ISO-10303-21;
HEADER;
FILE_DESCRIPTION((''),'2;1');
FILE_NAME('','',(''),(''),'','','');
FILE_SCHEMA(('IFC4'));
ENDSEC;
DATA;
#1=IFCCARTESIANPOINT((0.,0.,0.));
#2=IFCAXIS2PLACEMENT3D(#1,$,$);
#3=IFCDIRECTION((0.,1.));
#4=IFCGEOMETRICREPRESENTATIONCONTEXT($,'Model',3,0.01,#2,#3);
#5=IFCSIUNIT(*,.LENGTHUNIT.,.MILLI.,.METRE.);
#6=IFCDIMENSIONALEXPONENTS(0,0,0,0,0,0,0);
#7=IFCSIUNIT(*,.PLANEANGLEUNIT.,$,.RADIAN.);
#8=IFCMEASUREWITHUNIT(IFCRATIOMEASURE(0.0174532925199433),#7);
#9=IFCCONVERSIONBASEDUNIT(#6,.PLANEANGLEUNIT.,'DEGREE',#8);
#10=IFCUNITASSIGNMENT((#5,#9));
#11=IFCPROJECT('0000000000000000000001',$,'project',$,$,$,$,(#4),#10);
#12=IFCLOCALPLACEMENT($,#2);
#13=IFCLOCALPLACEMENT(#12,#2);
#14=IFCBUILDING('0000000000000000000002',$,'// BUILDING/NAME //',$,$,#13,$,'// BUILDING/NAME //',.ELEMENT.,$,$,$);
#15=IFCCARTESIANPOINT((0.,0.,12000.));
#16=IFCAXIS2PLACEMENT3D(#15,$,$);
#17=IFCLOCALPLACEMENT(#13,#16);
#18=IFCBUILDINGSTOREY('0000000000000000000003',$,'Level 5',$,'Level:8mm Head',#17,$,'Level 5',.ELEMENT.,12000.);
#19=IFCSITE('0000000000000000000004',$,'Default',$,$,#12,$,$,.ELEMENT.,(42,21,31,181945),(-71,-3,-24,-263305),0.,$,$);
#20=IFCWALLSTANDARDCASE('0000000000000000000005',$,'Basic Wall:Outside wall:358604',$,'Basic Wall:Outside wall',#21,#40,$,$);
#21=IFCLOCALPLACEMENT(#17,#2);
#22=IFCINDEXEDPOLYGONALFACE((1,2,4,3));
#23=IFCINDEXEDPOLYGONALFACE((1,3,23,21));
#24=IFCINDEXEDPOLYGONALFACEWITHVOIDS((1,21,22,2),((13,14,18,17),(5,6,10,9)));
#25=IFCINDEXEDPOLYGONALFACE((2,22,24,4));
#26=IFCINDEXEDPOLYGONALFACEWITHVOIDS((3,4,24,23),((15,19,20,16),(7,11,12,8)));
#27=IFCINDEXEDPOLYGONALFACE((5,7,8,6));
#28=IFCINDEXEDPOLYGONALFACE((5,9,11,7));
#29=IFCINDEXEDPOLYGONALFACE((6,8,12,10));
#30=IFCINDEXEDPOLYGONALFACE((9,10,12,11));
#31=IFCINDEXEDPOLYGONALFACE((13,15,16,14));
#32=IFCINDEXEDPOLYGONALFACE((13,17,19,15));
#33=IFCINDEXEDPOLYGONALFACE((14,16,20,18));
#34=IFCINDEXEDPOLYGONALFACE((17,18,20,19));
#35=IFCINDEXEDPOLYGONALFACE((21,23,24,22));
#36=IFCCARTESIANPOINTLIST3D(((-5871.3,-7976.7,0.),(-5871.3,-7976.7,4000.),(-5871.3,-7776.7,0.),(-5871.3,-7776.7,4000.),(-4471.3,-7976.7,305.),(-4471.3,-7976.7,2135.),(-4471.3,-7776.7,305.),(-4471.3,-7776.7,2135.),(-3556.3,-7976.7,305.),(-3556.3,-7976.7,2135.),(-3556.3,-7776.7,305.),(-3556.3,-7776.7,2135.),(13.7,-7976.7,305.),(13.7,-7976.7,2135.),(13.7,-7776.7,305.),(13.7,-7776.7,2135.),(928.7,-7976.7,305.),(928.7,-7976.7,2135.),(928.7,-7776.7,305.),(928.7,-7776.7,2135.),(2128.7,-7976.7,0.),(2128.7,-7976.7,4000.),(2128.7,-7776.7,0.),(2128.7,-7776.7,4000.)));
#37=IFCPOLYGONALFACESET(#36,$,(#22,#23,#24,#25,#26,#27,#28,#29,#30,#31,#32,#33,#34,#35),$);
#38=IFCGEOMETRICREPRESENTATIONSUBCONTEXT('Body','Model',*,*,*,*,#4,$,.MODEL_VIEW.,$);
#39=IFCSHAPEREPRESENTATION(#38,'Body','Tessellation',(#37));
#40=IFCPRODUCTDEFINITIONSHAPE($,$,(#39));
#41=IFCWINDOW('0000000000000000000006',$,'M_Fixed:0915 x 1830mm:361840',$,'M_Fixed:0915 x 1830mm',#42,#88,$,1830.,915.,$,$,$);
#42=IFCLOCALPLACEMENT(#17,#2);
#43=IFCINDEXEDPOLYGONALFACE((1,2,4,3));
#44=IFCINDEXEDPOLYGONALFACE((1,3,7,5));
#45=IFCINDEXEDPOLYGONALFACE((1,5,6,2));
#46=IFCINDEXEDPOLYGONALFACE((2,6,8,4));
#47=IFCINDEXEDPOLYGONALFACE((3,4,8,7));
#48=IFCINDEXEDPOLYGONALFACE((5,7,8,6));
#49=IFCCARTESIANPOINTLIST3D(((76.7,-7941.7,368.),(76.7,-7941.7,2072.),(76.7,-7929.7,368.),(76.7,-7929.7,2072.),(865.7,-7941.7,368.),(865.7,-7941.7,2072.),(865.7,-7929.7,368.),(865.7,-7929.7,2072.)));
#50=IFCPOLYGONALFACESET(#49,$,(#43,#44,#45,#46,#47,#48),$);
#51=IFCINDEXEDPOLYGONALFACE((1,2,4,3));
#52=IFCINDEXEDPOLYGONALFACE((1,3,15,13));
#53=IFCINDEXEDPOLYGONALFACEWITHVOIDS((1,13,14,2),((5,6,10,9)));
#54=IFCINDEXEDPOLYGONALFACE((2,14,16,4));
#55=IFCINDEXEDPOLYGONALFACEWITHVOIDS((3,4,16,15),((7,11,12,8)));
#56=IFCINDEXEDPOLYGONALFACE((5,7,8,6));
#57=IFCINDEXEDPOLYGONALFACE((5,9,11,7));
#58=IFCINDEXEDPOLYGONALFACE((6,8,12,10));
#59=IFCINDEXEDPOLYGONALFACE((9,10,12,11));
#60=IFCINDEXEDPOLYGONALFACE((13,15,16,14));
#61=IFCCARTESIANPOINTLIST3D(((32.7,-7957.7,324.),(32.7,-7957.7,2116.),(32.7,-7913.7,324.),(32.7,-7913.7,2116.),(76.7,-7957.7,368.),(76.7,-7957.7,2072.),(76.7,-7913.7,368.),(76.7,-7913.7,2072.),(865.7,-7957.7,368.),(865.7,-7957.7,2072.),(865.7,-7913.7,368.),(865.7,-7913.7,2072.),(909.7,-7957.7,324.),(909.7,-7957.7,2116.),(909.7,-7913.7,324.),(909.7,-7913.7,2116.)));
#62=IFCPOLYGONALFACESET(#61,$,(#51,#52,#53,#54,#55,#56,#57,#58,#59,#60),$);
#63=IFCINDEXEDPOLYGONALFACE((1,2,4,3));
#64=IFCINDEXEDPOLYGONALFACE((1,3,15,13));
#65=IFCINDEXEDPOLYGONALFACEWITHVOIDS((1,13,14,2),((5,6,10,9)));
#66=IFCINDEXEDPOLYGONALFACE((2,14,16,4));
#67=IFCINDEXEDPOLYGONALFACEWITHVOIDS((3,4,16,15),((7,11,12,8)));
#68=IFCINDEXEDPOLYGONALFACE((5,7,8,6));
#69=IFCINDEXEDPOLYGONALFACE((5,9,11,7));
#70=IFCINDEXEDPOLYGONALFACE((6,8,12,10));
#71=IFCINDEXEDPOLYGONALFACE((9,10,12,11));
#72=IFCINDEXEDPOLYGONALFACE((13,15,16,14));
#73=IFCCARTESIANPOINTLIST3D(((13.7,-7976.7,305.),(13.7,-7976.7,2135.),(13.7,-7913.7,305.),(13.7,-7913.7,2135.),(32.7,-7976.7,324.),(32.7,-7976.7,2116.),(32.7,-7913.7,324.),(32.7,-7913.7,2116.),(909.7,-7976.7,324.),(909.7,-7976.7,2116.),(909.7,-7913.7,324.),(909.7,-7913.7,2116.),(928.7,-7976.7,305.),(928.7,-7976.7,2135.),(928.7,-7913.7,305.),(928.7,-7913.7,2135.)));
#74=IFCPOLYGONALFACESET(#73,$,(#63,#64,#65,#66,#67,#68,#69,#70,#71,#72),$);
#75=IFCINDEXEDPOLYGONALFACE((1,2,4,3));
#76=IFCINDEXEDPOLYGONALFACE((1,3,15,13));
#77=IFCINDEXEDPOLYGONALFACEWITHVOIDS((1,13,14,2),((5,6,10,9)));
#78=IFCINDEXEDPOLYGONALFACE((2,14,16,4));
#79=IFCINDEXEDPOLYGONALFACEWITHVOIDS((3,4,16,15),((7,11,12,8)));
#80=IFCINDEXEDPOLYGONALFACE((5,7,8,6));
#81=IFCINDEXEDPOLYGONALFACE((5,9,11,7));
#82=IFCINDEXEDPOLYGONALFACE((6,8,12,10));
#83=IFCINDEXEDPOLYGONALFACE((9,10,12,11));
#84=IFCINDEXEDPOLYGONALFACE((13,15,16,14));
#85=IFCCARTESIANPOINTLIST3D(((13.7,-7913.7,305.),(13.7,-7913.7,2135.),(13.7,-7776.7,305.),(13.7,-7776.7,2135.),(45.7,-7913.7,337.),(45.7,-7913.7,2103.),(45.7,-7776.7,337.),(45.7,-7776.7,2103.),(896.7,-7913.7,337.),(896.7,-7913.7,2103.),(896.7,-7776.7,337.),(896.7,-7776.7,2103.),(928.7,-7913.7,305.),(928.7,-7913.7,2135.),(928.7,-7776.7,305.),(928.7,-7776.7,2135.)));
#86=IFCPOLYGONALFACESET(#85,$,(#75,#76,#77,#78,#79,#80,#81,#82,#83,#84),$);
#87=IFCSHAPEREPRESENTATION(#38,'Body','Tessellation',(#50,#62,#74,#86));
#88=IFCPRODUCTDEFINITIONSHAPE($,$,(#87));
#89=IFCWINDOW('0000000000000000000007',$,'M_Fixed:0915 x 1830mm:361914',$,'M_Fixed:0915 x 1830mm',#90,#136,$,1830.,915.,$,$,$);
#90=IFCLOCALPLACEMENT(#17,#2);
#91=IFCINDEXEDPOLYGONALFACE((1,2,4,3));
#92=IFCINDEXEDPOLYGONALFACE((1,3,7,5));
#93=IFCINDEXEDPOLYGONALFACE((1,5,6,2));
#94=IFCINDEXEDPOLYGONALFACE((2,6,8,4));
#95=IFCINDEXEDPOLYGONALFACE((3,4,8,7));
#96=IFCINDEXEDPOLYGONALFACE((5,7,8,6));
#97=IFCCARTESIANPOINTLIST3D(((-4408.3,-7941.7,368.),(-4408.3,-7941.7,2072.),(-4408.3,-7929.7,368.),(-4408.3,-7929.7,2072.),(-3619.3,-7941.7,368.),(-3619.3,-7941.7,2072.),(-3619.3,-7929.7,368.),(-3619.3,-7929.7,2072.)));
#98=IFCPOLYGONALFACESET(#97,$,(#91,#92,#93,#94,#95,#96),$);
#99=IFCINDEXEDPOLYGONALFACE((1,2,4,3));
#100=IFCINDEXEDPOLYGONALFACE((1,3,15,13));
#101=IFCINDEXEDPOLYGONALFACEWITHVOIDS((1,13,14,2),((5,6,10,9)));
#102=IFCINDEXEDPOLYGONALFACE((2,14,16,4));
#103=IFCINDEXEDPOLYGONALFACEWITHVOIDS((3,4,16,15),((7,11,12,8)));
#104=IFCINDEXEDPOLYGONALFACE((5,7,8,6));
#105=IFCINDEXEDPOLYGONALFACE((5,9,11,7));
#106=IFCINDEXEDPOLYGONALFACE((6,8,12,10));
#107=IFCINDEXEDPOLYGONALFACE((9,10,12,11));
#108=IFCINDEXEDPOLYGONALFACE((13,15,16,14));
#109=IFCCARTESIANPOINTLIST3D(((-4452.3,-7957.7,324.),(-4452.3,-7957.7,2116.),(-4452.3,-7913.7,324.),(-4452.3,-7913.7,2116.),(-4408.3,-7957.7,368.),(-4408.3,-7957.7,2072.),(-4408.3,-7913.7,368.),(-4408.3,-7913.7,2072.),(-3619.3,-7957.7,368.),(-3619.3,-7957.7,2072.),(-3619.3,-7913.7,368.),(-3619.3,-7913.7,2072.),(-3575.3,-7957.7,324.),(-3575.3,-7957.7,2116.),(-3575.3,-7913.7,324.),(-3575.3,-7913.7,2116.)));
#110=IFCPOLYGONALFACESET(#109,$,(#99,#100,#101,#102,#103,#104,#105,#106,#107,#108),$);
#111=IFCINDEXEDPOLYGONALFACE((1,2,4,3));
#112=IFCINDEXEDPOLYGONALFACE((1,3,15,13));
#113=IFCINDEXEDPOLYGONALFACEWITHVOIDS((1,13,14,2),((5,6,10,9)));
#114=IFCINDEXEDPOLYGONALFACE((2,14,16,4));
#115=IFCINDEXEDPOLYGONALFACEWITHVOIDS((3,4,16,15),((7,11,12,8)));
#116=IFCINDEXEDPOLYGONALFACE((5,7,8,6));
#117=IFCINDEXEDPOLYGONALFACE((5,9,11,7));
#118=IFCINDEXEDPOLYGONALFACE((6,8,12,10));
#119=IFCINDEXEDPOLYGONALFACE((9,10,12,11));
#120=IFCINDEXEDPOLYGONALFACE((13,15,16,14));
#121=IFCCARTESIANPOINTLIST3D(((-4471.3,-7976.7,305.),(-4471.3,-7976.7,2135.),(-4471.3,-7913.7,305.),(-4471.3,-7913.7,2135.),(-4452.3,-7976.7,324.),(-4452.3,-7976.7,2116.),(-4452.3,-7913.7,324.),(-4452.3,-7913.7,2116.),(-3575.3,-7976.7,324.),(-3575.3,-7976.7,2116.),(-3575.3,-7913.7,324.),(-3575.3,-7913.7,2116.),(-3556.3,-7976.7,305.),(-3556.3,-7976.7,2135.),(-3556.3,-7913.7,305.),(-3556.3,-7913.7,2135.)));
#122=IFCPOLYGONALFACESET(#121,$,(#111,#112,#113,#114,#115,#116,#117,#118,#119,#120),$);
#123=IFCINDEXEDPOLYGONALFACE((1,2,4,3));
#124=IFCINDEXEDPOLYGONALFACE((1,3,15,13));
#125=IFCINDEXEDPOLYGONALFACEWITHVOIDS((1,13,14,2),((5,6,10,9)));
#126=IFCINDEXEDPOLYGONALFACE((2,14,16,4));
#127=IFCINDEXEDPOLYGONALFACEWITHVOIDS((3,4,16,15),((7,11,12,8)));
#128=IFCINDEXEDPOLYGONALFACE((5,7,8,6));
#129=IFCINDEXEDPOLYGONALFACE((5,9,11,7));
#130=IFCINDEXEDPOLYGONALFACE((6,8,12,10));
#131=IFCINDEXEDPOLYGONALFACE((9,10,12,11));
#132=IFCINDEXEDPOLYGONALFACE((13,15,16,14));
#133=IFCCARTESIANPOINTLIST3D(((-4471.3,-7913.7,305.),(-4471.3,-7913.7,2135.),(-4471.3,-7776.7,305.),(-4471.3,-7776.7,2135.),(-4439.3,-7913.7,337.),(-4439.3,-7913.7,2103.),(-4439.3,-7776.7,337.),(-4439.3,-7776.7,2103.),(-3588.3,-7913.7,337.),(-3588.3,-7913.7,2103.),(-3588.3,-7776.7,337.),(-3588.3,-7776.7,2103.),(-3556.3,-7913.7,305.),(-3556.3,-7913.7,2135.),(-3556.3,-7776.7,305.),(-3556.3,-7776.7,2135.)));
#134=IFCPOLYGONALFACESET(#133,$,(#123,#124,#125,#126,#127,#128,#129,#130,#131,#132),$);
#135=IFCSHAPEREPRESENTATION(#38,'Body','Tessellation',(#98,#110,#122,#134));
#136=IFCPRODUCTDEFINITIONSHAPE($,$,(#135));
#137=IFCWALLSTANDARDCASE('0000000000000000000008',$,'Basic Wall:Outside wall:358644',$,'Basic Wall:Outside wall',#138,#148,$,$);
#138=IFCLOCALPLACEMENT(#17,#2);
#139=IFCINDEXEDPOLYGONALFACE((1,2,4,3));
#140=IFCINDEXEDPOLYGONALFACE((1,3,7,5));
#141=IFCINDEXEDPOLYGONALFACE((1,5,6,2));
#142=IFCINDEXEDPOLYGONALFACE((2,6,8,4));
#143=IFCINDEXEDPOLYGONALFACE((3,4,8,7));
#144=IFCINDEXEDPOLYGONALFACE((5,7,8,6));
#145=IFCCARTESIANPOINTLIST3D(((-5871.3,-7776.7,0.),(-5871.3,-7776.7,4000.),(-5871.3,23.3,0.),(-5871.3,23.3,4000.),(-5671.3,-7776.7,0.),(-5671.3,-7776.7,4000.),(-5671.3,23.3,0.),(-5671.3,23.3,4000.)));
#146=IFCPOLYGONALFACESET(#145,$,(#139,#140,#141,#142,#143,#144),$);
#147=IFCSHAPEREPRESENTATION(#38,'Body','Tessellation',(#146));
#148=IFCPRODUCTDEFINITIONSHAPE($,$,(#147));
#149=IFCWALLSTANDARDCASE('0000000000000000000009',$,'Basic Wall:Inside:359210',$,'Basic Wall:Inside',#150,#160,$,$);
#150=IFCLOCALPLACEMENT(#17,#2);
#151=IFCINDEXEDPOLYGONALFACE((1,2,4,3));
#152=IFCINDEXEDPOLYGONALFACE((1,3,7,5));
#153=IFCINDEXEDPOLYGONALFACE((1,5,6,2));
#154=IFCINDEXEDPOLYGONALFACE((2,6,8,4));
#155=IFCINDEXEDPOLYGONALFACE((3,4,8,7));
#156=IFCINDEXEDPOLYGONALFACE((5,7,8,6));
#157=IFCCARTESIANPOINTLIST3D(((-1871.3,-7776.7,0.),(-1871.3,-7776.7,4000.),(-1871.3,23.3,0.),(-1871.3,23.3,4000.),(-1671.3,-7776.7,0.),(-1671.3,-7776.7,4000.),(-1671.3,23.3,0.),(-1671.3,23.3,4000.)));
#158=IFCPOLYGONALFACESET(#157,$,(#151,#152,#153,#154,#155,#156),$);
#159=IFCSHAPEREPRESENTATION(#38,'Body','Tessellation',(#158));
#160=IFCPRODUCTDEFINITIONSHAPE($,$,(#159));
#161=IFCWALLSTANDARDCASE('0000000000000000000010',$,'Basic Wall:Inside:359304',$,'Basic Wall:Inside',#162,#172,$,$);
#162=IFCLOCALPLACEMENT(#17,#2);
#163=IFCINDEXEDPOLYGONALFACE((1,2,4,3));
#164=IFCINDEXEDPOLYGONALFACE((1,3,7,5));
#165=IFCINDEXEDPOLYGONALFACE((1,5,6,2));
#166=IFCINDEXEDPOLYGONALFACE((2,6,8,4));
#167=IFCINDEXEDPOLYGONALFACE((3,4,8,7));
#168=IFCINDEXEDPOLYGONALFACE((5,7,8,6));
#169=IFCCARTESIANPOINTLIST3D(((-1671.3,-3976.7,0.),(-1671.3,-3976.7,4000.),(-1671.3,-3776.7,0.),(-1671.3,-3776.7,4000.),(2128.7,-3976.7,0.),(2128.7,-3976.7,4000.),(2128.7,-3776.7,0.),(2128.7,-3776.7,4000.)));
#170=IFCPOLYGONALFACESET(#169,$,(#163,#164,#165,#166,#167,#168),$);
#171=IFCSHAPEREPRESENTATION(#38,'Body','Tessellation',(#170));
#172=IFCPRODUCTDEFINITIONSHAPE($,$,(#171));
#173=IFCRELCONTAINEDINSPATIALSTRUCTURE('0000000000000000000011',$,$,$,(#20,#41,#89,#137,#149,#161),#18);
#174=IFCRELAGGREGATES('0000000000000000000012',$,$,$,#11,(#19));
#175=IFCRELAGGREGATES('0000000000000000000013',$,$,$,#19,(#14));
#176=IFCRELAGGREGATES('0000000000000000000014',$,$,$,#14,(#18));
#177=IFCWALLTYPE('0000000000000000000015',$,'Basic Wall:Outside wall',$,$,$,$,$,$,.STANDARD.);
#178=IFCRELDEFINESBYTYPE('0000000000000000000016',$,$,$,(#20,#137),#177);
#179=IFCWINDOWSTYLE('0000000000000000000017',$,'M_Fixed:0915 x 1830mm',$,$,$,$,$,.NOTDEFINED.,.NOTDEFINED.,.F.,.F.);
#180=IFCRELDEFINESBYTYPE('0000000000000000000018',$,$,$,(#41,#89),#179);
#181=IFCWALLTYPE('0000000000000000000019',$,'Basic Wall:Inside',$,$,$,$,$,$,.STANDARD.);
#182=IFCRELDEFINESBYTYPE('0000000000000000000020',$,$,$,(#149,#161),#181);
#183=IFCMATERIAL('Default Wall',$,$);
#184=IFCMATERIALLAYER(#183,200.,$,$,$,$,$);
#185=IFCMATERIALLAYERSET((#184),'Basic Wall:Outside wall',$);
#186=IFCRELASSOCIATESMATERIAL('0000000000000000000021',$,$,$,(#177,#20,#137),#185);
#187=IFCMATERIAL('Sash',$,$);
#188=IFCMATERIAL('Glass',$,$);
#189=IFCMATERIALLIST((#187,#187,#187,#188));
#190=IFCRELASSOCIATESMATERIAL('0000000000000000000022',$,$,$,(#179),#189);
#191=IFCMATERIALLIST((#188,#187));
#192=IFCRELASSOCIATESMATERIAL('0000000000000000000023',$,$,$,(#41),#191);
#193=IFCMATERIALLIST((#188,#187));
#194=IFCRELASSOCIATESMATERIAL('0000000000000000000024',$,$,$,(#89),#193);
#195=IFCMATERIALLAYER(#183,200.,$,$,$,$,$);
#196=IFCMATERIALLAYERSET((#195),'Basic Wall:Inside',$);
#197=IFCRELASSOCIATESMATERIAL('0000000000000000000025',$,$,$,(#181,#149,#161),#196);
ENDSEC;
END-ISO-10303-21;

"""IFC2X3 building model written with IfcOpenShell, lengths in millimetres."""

from ifc_helpers import new_model, entity, si_unit, converted_unit, direction, frame, frame_2d, origin, place, context, subcontext, project, spatial, polyline, rectangle, outline, extrude, clip, halfspace, source, transform, mapped, material, material_list, layer, layer_set, layer_usage, type_object, type_shapes, element, fill, save


model = new_model("IFC2X3")

# Units and contexts
model_context = context("Model", 3, precision=0.01, world=origin(), true_north=direction((0.0, 1.0)))
body_context = subcontext(model_context, "Body", "Model", "MODEL_VIEW")
ifc_project = project(units=[si_unit("LENGTHUNIT", "METRE", prefix="MILLI"), converted_unit("PLANEANGLEUNIT", "DEGREE", entity("IfcRatioMeasure", 0.0174532925199433), si_unit("PLANEANGLEUNIT", "RADIAN"), dimensions=[0, 0, 0, 0, 0, 0, 0])], contexts=[model_context])

# Site, building, storey
site_placement = place(None, origin())
site = spatial("IfcSite", under=ifc_project, at=site_placement, Name="Default", CompositionType="ELEMENT", RefLatitude=(42, 21, 31, 181945), RefLongitude=(-71, -3, -24, -263305), RefElevation=0.0)
building_placement = place(site_placement, origin())
building = spatial("IfcBuilding", under=site, at=building_placement, Name="// BUILDING/NAME //", LongName="// BUILDING/NAME //", CompositionType="ELEMENT")
storey_placement = place(building_placement, frame((0.0, 0.0, 12000.0)))
storey = spatial("IfcBuildingStorey", under=building, at=storey_placement, Name="Level 5", ObjectType="Level:8mm Head", LongName="Level 5", CompositionType="ELEMENT", Elevation=12000.0)

# Shared definitions
ifc_material_1 = material(Name="Default Wall")
ifc_layer_1 = layer(ifc_material_1, 200.0)
ifc_layer_set_1 = layer_set([ifc_layer_1], Name="Basic Wall:Outside wall")
wall_type_1 = type_object("IfcWallType", Name="Basic Wall:Outside wall", PredefinedType="STANDARD", material=ifc_layer_set_1)
ifc_material_2 = material(Name="Glass")
ifc_material_3 = material(Name="Sash")
ifc_material_list_1 = material_list([ifc_material_3, ifc_material_3, ifc_material_3, ifc_material_2])
window_style = type_object("IfcWindowStyle", Name="M_Fixed:0915 x 1830mm", ConstructionType="NOTDEFINED", OperationType="NOTDEFINED", ParameterTakesPrecedence=False, Sizeable=False, material=ifc_material_list_1)
shared_shape = source(origin(), body_context, "Body", "SweptSolid", [
    extrude(rectangle(XDim=12.0, YDim=789.0, at=frame_2d((0.0, 0.0), x_axis=(1.0, 0.0))), frame((457.5, 159.0, 63.0), z_axis=(0.0, 0.0, 1.0), x_axis=(0.0, -1.0, 0.0)), (0.0, 0.0, 1.0), 1704.0),
    extrude(outline(polyline([(-438.5, -896.0), (438.5, -896.0), (438.5, 896.0), (-438.5, 896.0), (-438.5, -896.0)]), holes=[polyline([(-394.5, -852.0), (-394.5, 852.0), (394.5, 852.0), (394.5, -852.0), (-394.5, -852.0)])]), frame((457.5, 137.0, 915.0), z_axis=(0.0, 1.0, 0.0), x_axis=(1.0, 0.0, 0.0)), (0.0, 0.0, 1.0), 44.0),
    extrude(outline(polyline([(-457.5, -915.0), (457.5, -915.0), (457.5, 915.0), (-457.5, 915.0), (-457.5, -915.0)]), holes=[polyline([(-438.5, -896.0), (-438.5, 896.0), (438.5, 896.0), (438.5, -896.0), (-438.5, -896.0)])]), frame((457.5, 137.0, 915.0), z_axis=(0.0, 1.0, 0.0), x_axis=(1.0, 0.0, 0.0)), (0.0, 0.0, 1.0), 63.0),
    extrude(outline(polyline([(-457.5, -915.0), (457.5, -915.0), (457.5, 915.0), (-457.5, 915.0), (-457.5, -915.0)]), holes=[polyline([(-425.5, -883.0), (-425.5, 883.0), (425.5, 883.0), (425.5, -883.0), (-425.5, -883.0)])]), frame((457.5, 0.0, 915.0), z_axis=(0.0, 1.0, 0.0), x_axis=(1.0, 0.0, 0.0)), (0.0, 0.0, 1.0), 137.0),
])
type_shapes(window_style, [shared_shape])

# Wall, openings, windows
ifc_layer_usage_1 = layer_usage(ifc_layer_set_1, "AXIS2", "NEGATIVE", 100.0)
wall_1_placement = place(storey_placement, frame((2128.7, -7876.7, 0.0), z_axis=(0.0, 0.0, 1.0), x_axis=(-1.0, 0.0, 0.0)))
wall_1 = element("IfcWallStandardCase", 1, at=wall_1_placement, inside=storey, type_object=wall_type_1, material=ifc_layer_usage_1, Name="Basic Wall:Outside wall:358604", ObjectType="Basic Wall:Outside wall", context=body_context, shape_type="Clipping", body=[
    clip(extrude(rectangle(XDim=8000.0, YDim=200.0, at=frame_2d((4000.0, 0.0), x_axis=(-1.0, 0.0))), origin(), (0.0, 0.0, 1.0), 4000.0), halfspace(frame((0.0, 0.0, -12000.0)), True)),
])
opening_1_placement = place(wall_1_placement, frame((1200.0, -100.0, 305.0)))
opening_1 = element("IfcOpeningElement", 2, at=opening_1_placement, cuts=wall_1, ObjectType="Opening", context=body_context, shape_type="SweptSolid", body=[
    extrude(rectangle(XDim=1830.0, YDim=915.0, at=frame_2d((915.0, 457.5), x_axis=(1.0, 0.0))), frame((0.0, 0.0, 0.0), z_axis=(0.0, 1.0, 0.0), x_axis=(0.0, 0.0, 1.0)), (0.0, 0.0, 1.0), 200.0),
])
opening_2_placement = place(wall_1_placement, frame((5685.0, -100.0, 305.0)))
opening_2 = element("IfcOpeningElement", 3, at=opening_2_placement, cuts=wall_1, ObjectType="Opening", context=body_context, shape_type="SweptSolid", body=[
    extrude(rectangle(XDim=1830.0, YDim=915.0, at=frame_2d((915.0, 457.5), x_axis=(1.0, 0.0))), frame((0.0, 0.0, 0.0), z_axis=(0.0, 1.0, 0.0), x_axis=(0.0, 0.0, 1.0)), (0.0, 0.0, 1.0), 200.0),
])
ifc_material_list_2 = material_list([ifc_material_2, ifc_material_3])
window_1_placement = place(opening_1_placement, origin())
window_1 = element("IfcWindow", 4, at=window_1_placement, inside=storey, type_object=window_style, material=ifc_material_list_2, Name="M_Fixed:0915 x 1830mm:361840", ObjectType="M_Fixed:0915 x 1830mm", OverallHeight=1830.0, OverallWidth=915.0, context=body_context, shape_type="MappedRepresentation", body=[
    mapped(shared_shape, transform((0.0, 0.0, 0.0), scale=1.0)),
])
fill(opening_1, window_1)
ifc_material_list_3 = material_list([ifc_material_2, ifc_material_3])
window_2_placement = place(opening_2_placement, origin())
window_2 = element("IfcWindow", 5, at=window_2_placement, inside=storey, type_object=window_style, material=ifc_material_list_3, Name="M_Fixed:0915 x 1830mm:361914", ObjectType="M_Fixed:0915 x 1830mm", OverallHeight=1830.0, OverallWidth=915.0, context=body_context, shape_type="MappedRepresentation", body=[
    mapped(shared_shape, transform((0.0, 0.0, 0.0), scale=1.0)),
])
fill(opening_2, window_2)

# Walls
ifc_layer_usage_2 = layer_usage(ifc_layer_set_1, "AXIS2", "NEGATIVE", 100.0)
wall_2_placement = place(storey_placement, frame((-5771.3, -7776.7, 0.0), z_axis=(0.0, 0.0, 1.0), x_axis=(0.0, 1.0, 0.0)))
element("IfcWallStandardCase", 6, at=wall_2_placement, inside=storey, type_object=wall_type_1, material=ifc_layer_usage_2, Name="Basic Wall:Outside wall:358644", ObjectType="Basic Wall:Outside wall", context=body_context, shape_type="Clipping", body=[
    clip(extrude(rectangle(XDim=7800.0, YDim=200.0, at=frame_2d((3900.0, 0.0), x_axis=(-1.0, 0.0))), origin(), (0.0, 0.0, 1.0), 4000.0), halfspace(frame((0.0, 0.0, -12000.0)), True)),
])
ifc_layer_2 = layer(ifc_material_1, 200.0)
ifc_layer_set_2 = layer_set([ifc_layer_2], Name="Basic Wall:Inside")
ifc_layer_usage_3 = layer_usage(ifc_layer_set_2, "AXIS2", "NEGATIVE", 100.0)
wall_type_2 = type_object("IfcWallType", Name="Basic Wall:Inside", PredefinedType="STANDARD", material=ifc_layer_set_2)
wall_3_placement = place(storey_placement, frame((-1771.3, 23.3, 0.0), z_axis=(0.0, 0.0, 1.0), x_axis=(0.0, -1.0, 0.0)))
element("IfcWallStandardCase", 7, at=wall_3_placement, inside=storey, type_object=wall_type_2, material=ifc_layer_usage_3, Name="Basic Wall:Inside:359210", ObjectType="Basic Wall:Inside", context=body_context, shape_type="Clipping", body=[
    clip(extrude(rectangle(XDim=7800.0, YDim=200.0, at=frame_2d((3900.0, 0.0), x_axis=(-1.0, 0.0))), origin(), (0.0, 0.0, 1.0), 4000.0), halfspace(frame((0.0, 0.0, -12000.0)), True)),
])
ifc_layer_usage_4 = layer_usage(ifc_layer_set_2, "AXIS2", "NEGATIVE", 100.0)
wall_4_placement = place(storey_placement, frame((-1671.3, -3876.7, 0.0)))
element("IfcWallStandardCase", 8, at=wall_4_placement, inside=storey, type_object=wall_type_2, material=ifc_layer_usage_4, Name="Basic Wall:Inside:359304", ObjectType="Basic Wall:Inside", context=body_context, shape_type="Clipping", body=[
    clip(extrude(rectangle(XDim=3800.0, YDim=200.0, at=frame_2d((1900.0, 0.0), x_axis=(-1.0, 0.0))), origin(), (0.0, 0.0, 1.0), 4000.0), halfspace(frame((0.0, 0.0, -12000.0)), True)),
])

save(model, "model.ifc")
